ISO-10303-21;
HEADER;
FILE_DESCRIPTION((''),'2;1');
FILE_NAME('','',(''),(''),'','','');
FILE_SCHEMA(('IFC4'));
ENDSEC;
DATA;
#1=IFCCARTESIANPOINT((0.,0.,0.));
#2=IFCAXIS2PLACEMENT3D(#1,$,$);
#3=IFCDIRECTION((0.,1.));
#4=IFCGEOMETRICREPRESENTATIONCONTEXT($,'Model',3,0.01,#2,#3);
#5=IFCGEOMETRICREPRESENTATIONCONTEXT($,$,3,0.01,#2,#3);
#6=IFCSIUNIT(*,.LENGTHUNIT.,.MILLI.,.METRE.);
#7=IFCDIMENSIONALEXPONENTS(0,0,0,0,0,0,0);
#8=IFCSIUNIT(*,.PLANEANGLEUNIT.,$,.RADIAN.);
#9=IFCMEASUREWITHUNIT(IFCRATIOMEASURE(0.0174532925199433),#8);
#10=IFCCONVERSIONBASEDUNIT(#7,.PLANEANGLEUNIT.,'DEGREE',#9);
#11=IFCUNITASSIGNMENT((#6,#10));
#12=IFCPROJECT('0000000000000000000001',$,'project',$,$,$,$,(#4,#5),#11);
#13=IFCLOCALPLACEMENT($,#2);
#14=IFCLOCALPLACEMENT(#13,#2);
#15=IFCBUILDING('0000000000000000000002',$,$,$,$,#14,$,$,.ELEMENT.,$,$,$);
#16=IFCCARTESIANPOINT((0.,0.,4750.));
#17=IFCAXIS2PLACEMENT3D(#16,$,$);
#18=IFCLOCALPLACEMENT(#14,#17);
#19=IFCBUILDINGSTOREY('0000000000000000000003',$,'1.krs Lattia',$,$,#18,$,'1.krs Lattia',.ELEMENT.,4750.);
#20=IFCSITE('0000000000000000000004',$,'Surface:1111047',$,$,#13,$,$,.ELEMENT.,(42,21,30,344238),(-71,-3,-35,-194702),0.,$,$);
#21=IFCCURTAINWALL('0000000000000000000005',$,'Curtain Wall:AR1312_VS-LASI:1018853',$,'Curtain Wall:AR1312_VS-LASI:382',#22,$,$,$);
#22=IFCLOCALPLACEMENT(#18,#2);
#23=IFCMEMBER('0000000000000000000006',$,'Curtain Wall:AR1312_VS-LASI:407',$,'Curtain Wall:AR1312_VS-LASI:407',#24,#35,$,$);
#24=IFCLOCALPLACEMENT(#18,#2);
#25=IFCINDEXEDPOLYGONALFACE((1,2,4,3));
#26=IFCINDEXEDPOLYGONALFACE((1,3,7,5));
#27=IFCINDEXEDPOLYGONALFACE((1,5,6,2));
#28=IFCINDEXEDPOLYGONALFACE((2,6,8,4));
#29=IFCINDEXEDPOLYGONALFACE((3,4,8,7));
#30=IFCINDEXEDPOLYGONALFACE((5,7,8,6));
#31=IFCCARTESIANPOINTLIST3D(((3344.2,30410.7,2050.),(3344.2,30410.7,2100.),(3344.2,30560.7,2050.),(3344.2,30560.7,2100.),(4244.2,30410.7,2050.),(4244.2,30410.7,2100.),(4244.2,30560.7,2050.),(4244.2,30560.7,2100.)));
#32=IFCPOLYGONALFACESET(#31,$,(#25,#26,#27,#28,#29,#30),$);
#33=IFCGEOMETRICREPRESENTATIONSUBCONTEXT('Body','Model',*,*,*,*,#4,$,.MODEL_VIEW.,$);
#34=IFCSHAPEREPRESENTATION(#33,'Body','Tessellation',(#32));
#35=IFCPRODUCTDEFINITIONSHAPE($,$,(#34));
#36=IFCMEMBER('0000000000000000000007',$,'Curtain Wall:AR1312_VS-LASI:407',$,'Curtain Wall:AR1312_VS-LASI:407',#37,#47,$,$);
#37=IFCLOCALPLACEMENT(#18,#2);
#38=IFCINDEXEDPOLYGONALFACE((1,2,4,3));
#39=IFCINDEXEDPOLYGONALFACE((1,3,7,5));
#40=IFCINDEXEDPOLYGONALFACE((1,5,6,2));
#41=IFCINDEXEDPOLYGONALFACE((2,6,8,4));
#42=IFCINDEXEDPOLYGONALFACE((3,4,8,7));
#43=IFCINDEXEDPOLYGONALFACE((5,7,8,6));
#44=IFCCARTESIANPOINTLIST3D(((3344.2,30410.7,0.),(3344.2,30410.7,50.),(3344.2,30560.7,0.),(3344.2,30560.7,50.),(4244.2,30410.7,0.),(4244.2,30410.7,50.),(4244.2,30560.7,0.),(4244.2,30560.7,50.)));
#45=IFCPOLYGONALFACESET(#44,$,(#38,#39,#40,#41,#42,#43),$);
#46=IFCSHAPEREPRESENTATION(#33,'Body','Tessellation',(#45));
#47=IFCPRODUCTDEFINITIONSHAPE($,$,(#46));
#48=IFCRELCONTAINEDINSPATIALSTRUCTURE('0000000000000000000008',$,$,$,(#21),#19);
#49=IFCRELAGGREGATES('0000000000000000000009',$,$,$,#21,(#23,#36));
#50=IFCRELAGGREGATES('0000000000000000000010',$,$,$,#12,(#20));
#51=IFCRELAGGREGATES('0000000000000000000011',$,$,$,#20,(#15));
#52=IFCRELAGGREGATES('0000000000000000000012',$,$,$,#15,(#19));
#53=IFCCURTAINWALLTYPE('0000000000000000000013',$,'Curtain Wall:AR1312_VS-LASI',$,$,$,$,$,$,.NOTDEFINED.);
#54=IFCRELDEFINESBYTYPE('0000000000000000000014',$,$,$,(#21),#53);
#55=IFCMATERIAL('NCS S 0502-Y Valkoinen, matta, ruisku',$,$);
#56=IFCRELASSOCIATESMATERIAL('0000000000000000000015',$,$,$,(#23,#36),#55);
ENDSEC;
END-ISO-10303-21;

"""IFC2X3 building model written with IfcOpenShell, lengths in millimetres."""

from ifc_helpers import new_model, entity, si_unit, converted_unit, direction, frame, frame_2d, origin, place, context, subcontext, project, spatial, rectangle, extrude, material, type_object, element, aggregate, save


model = new_model("IFC2X3")

# Units and contexts
model_context = context("Model", 3, precision=0.01, world=origin(), true_north=direction((0.0, 1.0)))
context_of_model = context(None, 3, precision=0.01, world=origin(), true_north=direction((0.0, 1.0)))
body_context = subcontext(model_context, "Body", "Model", "MODEL_VIEW")
ifc_project = project(units=[si_unit("LENGTHUNIT", "METRE", prefix="MILLI"), converted_unit("PLANEANGLEUNIT", "DEGREE", entity("IfcRatioMeasure", 0.0174532925199433), si_unit("PLANEANGLEUNIT", "RADIAN"), dimensions=[0, 0, 0, 0, 0, 0, 0])], contexts=[model_context, context_of_model])

# Site, building, storey
site_placement = place(None, origin())
site = spatial("IfcSite", under=ifc_project, at=site_placement, Name="Surface:1111047", CompositionType="ELEMENT", RefLatitude=(42, 21, 30, 344238), RefLongitude=(-71, -3, -35, -194702), RefElevation=0.0)
building_placement = place(site_placement, origin())
building = spatial("IfcBuilding", under=site, at=building_placement, CompositionType="ELEMENT")
storey_placement = place(building_placement, frame((0.0, 0.0, 4750.0)))
storey = spatial("IfcBuildingStorey", under=building, at=storey_placement, Name="1.krs Lattia", LongName="1.krs Lattia", CompositionType="ELEMENT", Elevation=4750.0)

# Curtain wall, members
curtain_wall_type = type_object("IfcCurtainWallType", Name="Curtain Wall:AR1312_VS-LASI", PredefinedType="NOTDEFINED")
ifc_material = material(Name="NCS S 0502-Y Valkoinen, matta, ruisku")
curtain_wall_1_placement = place(storey_placement, frame((0.0, 0.0, -4750.0)))
curtain_wall_1 = element("IfcCurtainWall", 1, at=curtain_wall_1_placement, inside=storey, type_object=curtain_wall_type, Name="Curtain Wall:AR1312_VS-LASI:1018853", ObjectType="Curtain Wall:AR1312_VS-LASI:382")
member_1_placement = place(curtain_wall_1_placement, frame((0.0, 0.0, 4750.0)))
member_1 = element("IfcMember", 2, at=member_1_placement, material=ifc_material, Name="Curtain Wall:AR1312_VS-LASI:407", ObjectType="Curtain Wall:AR1312_VS-LASI:407", context=body_context, shape_type="SweptSolid", body=[
    extrude(rectangle(XDim=50.0, YDim=150.0, at=frame_2d((0.0, 0.0), x_axis=(1.0, 0.0))), frame((4244.2, 30485.7, 2075.0), z_axis=(-1.0, 0.0, 0.0), x_axis=(0.0, 0.0, -1.0)), (0.0, 0.0, 1.0), 900.0),
])
member_2_placement = place(curtain_wall_1_placement, frame((0.0, 0.0, 4750.0)))
member_2 = element("IfcMember", 3, at=member_2_placement, material=ifc_material, Name="Curtain Wall:AR1312_VS-LASI:407", ObjectType="Curtain Wall:AR1312_VS-LASI:407", context=body_context, shape_type="SweptSolid", body=[
    extrude(rectangle(XDim=50.0, YDim=150.0, at=frame_2d((0.0, 0.0), x_axis=(1.0, 0.0))), frame((3344.2, 30485.7, 25.0), z_axis=(1.0, 0.0, 0.0), x_axis=(0.0, 0.0, -1.0)), (0.0, 0.0, 1.0), 900.0),
])
aggregate(curtain_wall_1, [member_1, member_2])

save(model, "model.ifc")
